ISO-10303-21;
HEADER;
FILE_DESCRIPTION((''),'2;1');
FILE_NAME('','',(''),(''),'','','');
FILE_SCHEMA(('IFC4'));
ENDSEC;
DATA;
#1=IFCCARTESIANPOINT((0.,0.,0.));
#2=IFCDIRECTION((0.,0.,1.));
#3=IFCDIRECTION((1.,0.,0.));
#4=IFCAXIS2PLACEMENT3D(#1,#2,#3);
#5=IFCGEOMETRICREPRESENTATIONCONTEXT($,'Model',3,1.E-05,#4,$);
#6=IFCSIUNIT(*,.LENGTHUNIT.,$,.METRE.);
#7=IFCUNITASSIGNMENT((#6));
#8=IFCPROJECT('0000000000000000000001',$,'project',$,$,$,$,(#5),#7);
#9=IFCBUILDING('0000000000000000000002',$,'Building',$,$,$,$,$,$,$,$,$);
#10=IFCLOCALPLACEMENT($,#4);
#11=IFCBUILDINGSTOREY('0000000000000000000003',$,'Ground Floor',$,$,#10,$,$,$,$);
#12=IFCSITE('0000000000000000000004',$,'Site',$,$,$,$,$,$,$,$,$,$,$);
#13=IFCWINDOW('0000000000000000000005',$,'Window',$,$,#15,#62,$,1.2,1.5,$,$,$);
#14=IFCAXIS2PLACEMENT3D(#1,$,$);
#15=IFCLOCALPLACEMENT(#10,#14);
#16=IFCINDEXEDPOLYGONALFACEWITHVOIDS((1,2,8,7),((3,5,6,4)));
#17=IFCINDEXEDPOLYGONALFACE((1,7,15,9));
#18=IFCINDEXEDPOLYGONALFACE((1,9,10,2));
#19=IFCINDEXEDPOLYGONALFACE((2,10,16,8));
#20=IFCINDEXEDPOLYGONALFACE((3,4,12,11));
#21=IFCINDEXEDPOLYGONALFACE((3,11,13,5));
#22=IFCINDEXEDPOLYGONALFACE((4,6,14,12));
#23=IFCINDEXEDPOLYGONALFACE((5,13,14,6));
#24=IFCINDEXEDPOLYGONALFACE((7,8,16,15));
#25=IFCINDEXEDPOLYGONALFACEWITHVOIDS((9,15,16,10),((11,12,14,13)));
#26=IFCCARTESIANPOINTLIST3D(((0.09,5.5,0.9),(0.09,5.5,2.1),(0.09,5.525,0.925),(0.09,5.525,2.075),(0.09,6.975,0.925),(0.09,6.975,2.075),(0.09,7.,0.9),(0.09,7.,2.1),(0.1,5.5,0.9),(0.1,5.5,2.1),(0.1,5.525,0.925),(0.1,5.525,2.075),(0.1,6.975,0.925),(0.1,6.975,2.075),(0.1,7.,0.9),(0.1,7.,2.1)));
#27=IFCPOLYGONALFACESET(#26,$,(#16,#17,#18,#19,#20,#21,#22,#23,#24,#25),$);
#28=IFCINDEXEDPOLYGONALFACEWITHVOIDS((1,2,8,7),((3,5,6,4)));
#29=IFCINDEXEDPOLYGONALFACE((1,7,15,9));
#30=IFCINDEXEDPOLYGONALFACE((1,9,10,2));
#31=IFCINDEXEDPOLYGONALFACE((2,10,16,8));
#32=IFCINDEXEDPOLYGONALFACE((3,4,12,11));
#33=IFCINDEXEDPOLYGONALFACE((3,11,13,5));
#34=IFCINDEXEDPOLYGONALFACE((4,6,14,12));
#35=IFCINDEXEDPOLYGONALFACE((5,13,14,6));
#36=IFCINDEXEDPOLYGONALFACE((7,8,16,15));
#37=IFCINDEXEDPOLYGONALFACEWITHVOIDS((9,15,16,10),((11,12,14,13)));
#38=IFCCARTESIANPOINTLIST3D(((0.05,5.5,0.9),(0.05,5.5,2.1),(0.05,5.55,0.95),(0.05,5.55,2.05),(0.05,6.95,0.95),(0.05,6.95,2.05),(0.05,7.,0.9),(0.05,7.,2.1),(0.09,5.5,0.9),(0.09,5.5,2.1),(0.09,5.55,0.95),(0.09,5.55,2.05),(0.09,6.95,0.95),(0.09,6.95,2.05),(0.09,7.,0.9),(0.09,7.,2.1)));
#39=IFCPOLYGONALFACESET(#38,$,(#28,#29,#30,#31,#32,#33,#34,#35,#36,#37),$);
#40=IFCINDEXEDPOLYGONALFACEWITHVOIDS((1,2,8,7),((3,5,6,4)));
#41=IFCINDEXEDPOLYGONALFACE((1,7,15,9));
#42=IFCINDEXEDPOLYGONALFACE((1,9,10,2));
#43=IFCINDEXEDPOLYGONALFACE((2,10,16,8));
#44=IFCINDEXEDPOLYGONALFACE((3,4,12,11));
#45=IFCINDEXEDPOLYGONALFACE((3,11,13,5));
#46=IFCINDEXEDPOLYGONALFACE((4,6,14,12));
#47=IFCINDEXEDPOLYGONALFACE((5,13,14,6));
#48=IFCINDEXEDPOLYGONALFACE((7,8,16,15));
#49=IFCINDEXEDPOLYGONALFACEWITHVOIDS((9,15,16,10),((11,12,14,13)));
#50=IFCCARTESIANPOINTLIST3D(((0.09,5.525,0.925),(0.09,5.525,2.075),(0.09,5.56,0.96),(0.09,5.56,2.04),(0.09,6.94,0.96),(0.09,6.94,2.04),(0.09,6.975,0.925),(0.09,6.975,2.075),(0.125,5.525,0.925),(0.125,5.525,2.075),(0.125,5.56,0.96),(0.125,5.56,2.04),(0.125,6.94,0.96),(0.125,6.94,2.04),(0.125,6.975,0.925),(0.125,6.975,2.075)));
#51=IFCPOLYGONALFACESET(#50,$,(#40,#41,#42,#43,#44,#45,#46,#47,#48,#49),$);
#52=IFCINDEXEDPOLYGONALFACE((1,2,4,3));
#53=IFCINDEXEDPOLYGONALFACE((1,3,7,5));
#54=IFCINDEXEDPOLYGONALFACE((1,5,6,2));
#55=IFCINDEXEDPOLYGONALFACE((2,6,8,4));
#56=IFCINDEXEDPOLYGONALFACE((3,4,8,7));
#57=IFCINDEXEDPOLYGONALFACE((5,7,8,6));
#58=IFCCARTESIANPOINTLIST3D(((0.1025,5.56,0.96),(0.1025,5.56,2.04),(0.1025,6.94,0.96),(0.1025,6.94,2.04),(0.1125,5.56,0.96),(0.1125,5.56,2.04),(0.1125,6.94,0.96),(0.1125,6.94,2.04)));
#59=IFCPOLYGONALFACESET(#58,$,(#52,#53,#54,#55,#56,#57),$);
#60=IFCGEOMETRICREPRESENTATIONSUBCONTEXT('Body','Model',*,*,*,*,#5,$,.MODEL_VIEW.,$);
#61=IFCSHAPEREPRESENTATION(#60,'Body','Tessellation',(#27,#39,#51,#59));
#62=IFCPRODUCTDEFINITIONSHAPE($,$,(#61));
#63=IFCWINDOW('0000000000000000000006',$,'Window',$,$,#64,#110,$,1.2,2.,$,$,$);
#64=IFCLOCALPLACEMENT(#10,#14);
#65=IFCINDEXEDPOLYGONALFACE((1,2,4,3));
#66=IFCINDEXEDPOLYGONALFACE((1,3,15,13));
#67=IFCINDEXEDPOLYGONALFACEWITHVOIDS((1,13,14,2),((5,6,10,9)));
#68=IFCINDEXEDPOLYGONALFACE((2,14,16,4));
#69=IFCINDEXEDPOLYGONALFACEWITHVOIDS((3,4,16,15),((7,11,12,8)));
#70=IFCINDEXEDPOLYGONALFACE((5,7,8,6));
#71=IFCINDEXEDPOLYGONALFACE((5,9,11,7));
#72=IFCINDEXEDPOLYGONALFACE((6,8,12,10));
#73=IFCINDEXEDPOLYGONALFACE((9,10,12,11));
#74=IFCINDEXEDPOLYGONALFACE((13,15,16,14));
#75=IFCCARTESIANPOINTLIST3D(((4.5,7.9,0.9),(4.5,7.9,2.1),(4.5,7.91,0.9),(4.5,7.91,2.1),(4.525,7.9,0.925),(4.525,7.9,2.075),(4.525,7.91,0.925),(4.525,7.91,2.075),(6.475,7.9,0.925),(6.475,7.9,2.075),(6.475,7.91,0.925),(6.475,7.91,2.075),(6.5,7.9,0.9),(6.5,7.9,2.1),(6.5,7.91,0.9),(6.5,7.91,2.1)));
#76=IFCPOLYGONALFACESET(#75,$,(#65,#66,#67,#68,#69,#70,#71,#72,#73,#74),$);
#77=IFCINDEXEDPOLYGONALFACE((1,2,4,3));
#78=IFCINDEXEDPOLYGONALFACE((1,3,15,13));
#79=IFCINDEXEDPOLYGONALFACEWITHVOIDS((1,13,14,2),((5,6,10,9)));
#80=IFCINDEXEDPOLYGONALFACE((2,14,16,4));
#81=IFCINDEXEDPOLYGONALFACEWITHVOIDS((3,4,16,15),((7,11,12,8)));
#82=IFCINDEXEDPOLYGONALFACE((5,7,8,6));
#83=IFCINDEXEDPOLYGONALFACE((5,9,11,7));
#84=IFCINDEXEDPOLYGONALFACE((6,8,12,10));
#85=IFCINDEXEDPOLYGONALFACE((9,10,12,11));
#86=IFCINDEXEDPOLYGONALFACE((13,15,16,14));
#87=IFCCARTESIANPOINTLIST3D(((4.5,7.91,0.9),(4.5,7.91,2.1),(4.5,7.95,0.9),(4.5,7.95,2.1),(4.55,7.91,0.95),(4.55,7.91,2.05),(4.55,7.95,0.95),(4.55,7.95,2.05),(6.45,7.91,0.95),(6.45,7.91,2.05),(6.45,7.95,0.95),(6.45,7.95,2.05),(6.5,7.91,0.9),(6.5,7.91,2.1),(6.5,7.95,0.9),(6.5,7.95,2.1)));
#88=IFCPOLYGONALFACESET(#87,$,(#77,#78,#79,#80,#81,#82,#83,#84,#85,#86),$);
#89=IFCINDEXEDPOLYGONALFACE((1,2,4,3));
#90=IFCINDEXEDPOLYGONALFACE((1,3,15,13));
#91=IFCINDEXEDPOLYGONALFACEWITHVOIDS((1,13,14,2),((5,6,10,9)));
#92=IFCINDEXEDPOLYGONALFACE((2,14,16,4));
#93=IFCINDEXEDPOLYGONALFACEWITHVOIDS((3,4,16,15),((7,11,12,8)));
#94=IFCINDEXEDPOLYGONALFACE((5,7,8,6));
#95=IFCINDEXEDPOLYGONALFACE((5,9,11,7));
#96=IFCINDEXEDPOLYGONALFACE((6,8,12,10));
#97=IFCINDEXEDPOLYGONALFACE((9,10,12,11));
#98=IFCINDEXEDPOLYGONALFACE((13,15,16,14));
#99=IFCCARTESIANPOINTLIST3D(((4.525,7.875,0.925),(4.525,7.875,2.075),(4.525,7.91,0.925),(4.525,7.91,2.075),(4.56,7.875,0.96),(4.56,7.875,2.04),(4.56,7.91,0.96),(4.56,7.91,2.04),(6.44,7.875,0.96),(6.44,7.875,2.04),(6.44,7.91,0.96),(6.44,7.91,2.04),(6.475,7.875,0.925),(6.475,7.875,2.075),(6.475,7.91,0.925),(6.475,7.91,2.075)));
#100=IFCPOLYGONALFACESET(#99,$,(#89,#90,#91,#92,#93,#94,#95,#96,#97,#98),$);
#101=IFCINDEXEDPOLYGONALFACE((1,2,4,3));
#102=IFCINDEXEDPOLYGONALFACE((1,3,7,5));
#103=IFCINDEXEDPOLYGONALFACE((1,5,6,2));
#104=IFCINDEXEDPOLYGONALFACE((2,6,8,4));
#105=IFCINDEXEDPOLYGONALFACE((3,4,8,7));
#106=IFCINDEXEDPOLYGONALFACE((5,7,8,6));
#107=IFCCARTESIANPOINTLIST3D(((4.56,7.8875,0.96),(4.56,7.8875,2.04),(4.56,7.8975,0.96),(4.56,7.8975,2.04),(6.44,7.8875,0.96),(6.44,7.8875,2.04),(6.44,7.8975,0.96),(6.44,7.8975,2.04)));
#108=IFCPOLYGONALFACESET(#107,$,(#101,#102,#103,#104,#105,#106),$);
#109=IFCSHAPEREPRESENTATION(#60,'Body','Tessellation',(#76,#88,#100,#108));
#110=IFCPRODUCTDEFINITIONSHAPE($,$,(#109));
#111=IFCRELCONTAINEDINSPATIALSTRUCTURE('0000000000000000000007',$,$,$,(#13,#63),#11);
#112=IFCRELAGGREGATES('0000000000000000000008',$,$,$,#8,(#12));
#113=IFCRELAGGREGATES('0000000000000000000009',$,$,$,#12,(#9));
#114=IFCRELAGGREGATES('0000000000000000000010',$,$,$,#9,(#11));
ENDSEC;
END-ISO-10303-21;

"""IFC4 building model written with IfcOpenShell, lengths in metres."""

from ifc_helpers import new_model, si_unit, frame, origin_with_axes, place, context, subcontext, project, spatial, line, indexed_curve, outline, extrude, element, save


model = new_model("IFC4")

# Units and contexts
model_context = context("Model", 3, precision=1e-05, world=origin_with_axes())
body_context = subcontext(model_context, "Body", "Model", "MODEL_VIEW")
ifc_project = project(units=[si_unit("LENGTHUNIT", "METRE")], contexts=[model_context])

# Site, building, storey
site = spatial("IfcSite", under=ifc_project, Name="Site")
building = spatial("IfcBuilding", under=site, Name="Building")
storey_placement = place(None, origin_with_axes())
storey = spatial("IfcBuildingStorey", under=building, at=storey_placement, Name="Ground Floor")

# Windows
window_1_placement = place(storey_placement, frame((0.0, 7.0, 0.9), z_axis=(0.0, 0.0, 1.0), x_axis=(0.0, -1.0, 0.0)))
element("IfcWindow", 1, at=window_1_placement, inside=storey, Name="Window", OverallHeight=1.2, OverallWidth=1.5, context=body_context, shape_type="SweptSolid", body=[
    extrude(outline(indexed_curve([(0.0, 0.0), (1.5, 0.0), (1.5, 1.2), (0.0, 1.2)], segments=[line(1, 2, 3, 4, 1)]), holes=[indexed_curve([(0.025, 0.025), (1.475, 0.025), (1.475, 1.175), (0.025, 1.175)], segments=[line(1, 2, 3, 4, 1)])]), frame((0.0, 0.09, 0.0), z_axis=(0.0, -1.0, 0.0), x_axis=(1.0, 0.0, 0.0)), (0.0, 0.0, -1.0), 0.01),
    extrude(outline(indexed_curve([(0.0, 0.0), (1.5, 0.0), (1.5, 1.2), (0.0, 1.2)], segments=[line(1, 2, 3, 4, 1)]), holes=[indexed_curve([(0.05, 0.05), (1.45, 0.05), (1.45, 1.15), (0.05, 1.15)], segments=[line(1, 2, 3, 4, 1)])]), frame((0.0, 0.05, 0.0), z_axis=(0.0, -1.0, 0.0), x_axis=(1.0, 0.0, 0.0)), (0.0, 0.0, -1.0), 0.04),
    extrude(outline(indexed_curve([(0.0, 0.0), (1.45, 0.0), (1.45, 1.15), (0.0, 1.15)], segments=[line(1, 2, 3, 4, 1)]), holes=[indexed_curve([(0.035, 0.035), (1.415, 0.035), (1.415, 1.115), (0.035, 1.115)], segments=[line(1, 2, 3, 4, 1)])]), frame((0.025, 0.09, 0.025), z_axis=(0.0, -1.0, 0.0), x_axis=(1.0, 0.0, 0.0)), (0.0, 0.0, -1.0), 0.035),
    extrude(outline(indexed_curve([(0.035, 0.035), (1.415, 0.035), (1.415, 1.115), (0.035, 1.115)], segments=[line(1, 2, 3, 4, 1)])), frame((0.025, 0.1025, 0.025), z_axis=(0.0, -1.0, 0.0), x_axis=(1.0, 0.0, 0.0)), (0.0, 0.0, -1.0), 0.01),
])
window_2_placement = place(storey_placement, frame((6.5, 8.0, 0.9), z_axis=(0.0, 0.0, 1.0), x_axis=(-1.0, 0.0, 0.0)))
element("IfcWindow", 2, at=window_2_placement, inside=storey, Name="Window", OverallHeight=1.2, OverallWidth=2.0, context=body_context, shape_type="SweptSolid", body=[
    extrude(outline(indexed_curve([(0.0, 0.0), (2.0, 0.0), (2.0, 1.2), (0.0, 1.2)], segments=[line(1, 2, 3, 4, 1)]), holes=[indexed_curve([(0.025, 0.025), (1.975, 0.025), (1.975, 1.175), (0.025, 1.175)], segments=[line(1, 2, 3, 4, 1)])]), frame((0.0, 0.09, 0.0), z_axis=(0.0, -1.0, 0.0), x_axis=(1.0, 0.0, 0.0)), (0.0, 0.0, -1.0), 0.01),
    extrude(outline(indexed_curve([(0.0, 0.0), (2.0, 0.0), (2.0, 1.2), (0.0, 1.2)], segments=[line(1, 2, 3, 4, 1)]), holes=[indexed_curve([(0.05, 0.05), (1.95, 0.05), (1.95, 1.15), (0.05, 1.15)], segments=[line(1, 2, 3, 4, 1)])]), frame((0.0, 0.05, 0.0), z_axis=(0.0, -1.0, 0.0), x_axis=(1.0, 0.0, 0.0)), (0.0, 0.0, -1.0), 0.04),
    extrude(outline(indexed_curve([(0.0, 0.0), (1.95, 0.0), (1.95, 1.15), (0.0, 1.15)], segments=[line(1, 2, 3, 4, 1)]), holes=[indexed_curve([(0.035, 0.035), (1.915, 0.035), (1.915, 1.115), (0.035, 1.115)], segments=[line(1, 2, 3, 4, 1)])]), frame((0.025, 0.09, 0.025), z_axis=(0.0, -1.0, 0.0), x_axis=(1.0, 0.0, 0.0)), (0.0, 0.0, -1.0), 0.035),
    extrude(outline(indexed_curve([(0.035, 0.035), (1.915, 0.035), (1.915, 1.115), (0.035, 1.115)], segments=[line(1, 2, 3, 4, 1)])), frame((0.025, 0.1025, 0.025), z_axis=(0.0, -1.0, 0.0), x_axis=(1.0, 0.0, 0.0)), (0.0, 0.0, -1.0), 0.01),
])

save(model, "model.ifc")
